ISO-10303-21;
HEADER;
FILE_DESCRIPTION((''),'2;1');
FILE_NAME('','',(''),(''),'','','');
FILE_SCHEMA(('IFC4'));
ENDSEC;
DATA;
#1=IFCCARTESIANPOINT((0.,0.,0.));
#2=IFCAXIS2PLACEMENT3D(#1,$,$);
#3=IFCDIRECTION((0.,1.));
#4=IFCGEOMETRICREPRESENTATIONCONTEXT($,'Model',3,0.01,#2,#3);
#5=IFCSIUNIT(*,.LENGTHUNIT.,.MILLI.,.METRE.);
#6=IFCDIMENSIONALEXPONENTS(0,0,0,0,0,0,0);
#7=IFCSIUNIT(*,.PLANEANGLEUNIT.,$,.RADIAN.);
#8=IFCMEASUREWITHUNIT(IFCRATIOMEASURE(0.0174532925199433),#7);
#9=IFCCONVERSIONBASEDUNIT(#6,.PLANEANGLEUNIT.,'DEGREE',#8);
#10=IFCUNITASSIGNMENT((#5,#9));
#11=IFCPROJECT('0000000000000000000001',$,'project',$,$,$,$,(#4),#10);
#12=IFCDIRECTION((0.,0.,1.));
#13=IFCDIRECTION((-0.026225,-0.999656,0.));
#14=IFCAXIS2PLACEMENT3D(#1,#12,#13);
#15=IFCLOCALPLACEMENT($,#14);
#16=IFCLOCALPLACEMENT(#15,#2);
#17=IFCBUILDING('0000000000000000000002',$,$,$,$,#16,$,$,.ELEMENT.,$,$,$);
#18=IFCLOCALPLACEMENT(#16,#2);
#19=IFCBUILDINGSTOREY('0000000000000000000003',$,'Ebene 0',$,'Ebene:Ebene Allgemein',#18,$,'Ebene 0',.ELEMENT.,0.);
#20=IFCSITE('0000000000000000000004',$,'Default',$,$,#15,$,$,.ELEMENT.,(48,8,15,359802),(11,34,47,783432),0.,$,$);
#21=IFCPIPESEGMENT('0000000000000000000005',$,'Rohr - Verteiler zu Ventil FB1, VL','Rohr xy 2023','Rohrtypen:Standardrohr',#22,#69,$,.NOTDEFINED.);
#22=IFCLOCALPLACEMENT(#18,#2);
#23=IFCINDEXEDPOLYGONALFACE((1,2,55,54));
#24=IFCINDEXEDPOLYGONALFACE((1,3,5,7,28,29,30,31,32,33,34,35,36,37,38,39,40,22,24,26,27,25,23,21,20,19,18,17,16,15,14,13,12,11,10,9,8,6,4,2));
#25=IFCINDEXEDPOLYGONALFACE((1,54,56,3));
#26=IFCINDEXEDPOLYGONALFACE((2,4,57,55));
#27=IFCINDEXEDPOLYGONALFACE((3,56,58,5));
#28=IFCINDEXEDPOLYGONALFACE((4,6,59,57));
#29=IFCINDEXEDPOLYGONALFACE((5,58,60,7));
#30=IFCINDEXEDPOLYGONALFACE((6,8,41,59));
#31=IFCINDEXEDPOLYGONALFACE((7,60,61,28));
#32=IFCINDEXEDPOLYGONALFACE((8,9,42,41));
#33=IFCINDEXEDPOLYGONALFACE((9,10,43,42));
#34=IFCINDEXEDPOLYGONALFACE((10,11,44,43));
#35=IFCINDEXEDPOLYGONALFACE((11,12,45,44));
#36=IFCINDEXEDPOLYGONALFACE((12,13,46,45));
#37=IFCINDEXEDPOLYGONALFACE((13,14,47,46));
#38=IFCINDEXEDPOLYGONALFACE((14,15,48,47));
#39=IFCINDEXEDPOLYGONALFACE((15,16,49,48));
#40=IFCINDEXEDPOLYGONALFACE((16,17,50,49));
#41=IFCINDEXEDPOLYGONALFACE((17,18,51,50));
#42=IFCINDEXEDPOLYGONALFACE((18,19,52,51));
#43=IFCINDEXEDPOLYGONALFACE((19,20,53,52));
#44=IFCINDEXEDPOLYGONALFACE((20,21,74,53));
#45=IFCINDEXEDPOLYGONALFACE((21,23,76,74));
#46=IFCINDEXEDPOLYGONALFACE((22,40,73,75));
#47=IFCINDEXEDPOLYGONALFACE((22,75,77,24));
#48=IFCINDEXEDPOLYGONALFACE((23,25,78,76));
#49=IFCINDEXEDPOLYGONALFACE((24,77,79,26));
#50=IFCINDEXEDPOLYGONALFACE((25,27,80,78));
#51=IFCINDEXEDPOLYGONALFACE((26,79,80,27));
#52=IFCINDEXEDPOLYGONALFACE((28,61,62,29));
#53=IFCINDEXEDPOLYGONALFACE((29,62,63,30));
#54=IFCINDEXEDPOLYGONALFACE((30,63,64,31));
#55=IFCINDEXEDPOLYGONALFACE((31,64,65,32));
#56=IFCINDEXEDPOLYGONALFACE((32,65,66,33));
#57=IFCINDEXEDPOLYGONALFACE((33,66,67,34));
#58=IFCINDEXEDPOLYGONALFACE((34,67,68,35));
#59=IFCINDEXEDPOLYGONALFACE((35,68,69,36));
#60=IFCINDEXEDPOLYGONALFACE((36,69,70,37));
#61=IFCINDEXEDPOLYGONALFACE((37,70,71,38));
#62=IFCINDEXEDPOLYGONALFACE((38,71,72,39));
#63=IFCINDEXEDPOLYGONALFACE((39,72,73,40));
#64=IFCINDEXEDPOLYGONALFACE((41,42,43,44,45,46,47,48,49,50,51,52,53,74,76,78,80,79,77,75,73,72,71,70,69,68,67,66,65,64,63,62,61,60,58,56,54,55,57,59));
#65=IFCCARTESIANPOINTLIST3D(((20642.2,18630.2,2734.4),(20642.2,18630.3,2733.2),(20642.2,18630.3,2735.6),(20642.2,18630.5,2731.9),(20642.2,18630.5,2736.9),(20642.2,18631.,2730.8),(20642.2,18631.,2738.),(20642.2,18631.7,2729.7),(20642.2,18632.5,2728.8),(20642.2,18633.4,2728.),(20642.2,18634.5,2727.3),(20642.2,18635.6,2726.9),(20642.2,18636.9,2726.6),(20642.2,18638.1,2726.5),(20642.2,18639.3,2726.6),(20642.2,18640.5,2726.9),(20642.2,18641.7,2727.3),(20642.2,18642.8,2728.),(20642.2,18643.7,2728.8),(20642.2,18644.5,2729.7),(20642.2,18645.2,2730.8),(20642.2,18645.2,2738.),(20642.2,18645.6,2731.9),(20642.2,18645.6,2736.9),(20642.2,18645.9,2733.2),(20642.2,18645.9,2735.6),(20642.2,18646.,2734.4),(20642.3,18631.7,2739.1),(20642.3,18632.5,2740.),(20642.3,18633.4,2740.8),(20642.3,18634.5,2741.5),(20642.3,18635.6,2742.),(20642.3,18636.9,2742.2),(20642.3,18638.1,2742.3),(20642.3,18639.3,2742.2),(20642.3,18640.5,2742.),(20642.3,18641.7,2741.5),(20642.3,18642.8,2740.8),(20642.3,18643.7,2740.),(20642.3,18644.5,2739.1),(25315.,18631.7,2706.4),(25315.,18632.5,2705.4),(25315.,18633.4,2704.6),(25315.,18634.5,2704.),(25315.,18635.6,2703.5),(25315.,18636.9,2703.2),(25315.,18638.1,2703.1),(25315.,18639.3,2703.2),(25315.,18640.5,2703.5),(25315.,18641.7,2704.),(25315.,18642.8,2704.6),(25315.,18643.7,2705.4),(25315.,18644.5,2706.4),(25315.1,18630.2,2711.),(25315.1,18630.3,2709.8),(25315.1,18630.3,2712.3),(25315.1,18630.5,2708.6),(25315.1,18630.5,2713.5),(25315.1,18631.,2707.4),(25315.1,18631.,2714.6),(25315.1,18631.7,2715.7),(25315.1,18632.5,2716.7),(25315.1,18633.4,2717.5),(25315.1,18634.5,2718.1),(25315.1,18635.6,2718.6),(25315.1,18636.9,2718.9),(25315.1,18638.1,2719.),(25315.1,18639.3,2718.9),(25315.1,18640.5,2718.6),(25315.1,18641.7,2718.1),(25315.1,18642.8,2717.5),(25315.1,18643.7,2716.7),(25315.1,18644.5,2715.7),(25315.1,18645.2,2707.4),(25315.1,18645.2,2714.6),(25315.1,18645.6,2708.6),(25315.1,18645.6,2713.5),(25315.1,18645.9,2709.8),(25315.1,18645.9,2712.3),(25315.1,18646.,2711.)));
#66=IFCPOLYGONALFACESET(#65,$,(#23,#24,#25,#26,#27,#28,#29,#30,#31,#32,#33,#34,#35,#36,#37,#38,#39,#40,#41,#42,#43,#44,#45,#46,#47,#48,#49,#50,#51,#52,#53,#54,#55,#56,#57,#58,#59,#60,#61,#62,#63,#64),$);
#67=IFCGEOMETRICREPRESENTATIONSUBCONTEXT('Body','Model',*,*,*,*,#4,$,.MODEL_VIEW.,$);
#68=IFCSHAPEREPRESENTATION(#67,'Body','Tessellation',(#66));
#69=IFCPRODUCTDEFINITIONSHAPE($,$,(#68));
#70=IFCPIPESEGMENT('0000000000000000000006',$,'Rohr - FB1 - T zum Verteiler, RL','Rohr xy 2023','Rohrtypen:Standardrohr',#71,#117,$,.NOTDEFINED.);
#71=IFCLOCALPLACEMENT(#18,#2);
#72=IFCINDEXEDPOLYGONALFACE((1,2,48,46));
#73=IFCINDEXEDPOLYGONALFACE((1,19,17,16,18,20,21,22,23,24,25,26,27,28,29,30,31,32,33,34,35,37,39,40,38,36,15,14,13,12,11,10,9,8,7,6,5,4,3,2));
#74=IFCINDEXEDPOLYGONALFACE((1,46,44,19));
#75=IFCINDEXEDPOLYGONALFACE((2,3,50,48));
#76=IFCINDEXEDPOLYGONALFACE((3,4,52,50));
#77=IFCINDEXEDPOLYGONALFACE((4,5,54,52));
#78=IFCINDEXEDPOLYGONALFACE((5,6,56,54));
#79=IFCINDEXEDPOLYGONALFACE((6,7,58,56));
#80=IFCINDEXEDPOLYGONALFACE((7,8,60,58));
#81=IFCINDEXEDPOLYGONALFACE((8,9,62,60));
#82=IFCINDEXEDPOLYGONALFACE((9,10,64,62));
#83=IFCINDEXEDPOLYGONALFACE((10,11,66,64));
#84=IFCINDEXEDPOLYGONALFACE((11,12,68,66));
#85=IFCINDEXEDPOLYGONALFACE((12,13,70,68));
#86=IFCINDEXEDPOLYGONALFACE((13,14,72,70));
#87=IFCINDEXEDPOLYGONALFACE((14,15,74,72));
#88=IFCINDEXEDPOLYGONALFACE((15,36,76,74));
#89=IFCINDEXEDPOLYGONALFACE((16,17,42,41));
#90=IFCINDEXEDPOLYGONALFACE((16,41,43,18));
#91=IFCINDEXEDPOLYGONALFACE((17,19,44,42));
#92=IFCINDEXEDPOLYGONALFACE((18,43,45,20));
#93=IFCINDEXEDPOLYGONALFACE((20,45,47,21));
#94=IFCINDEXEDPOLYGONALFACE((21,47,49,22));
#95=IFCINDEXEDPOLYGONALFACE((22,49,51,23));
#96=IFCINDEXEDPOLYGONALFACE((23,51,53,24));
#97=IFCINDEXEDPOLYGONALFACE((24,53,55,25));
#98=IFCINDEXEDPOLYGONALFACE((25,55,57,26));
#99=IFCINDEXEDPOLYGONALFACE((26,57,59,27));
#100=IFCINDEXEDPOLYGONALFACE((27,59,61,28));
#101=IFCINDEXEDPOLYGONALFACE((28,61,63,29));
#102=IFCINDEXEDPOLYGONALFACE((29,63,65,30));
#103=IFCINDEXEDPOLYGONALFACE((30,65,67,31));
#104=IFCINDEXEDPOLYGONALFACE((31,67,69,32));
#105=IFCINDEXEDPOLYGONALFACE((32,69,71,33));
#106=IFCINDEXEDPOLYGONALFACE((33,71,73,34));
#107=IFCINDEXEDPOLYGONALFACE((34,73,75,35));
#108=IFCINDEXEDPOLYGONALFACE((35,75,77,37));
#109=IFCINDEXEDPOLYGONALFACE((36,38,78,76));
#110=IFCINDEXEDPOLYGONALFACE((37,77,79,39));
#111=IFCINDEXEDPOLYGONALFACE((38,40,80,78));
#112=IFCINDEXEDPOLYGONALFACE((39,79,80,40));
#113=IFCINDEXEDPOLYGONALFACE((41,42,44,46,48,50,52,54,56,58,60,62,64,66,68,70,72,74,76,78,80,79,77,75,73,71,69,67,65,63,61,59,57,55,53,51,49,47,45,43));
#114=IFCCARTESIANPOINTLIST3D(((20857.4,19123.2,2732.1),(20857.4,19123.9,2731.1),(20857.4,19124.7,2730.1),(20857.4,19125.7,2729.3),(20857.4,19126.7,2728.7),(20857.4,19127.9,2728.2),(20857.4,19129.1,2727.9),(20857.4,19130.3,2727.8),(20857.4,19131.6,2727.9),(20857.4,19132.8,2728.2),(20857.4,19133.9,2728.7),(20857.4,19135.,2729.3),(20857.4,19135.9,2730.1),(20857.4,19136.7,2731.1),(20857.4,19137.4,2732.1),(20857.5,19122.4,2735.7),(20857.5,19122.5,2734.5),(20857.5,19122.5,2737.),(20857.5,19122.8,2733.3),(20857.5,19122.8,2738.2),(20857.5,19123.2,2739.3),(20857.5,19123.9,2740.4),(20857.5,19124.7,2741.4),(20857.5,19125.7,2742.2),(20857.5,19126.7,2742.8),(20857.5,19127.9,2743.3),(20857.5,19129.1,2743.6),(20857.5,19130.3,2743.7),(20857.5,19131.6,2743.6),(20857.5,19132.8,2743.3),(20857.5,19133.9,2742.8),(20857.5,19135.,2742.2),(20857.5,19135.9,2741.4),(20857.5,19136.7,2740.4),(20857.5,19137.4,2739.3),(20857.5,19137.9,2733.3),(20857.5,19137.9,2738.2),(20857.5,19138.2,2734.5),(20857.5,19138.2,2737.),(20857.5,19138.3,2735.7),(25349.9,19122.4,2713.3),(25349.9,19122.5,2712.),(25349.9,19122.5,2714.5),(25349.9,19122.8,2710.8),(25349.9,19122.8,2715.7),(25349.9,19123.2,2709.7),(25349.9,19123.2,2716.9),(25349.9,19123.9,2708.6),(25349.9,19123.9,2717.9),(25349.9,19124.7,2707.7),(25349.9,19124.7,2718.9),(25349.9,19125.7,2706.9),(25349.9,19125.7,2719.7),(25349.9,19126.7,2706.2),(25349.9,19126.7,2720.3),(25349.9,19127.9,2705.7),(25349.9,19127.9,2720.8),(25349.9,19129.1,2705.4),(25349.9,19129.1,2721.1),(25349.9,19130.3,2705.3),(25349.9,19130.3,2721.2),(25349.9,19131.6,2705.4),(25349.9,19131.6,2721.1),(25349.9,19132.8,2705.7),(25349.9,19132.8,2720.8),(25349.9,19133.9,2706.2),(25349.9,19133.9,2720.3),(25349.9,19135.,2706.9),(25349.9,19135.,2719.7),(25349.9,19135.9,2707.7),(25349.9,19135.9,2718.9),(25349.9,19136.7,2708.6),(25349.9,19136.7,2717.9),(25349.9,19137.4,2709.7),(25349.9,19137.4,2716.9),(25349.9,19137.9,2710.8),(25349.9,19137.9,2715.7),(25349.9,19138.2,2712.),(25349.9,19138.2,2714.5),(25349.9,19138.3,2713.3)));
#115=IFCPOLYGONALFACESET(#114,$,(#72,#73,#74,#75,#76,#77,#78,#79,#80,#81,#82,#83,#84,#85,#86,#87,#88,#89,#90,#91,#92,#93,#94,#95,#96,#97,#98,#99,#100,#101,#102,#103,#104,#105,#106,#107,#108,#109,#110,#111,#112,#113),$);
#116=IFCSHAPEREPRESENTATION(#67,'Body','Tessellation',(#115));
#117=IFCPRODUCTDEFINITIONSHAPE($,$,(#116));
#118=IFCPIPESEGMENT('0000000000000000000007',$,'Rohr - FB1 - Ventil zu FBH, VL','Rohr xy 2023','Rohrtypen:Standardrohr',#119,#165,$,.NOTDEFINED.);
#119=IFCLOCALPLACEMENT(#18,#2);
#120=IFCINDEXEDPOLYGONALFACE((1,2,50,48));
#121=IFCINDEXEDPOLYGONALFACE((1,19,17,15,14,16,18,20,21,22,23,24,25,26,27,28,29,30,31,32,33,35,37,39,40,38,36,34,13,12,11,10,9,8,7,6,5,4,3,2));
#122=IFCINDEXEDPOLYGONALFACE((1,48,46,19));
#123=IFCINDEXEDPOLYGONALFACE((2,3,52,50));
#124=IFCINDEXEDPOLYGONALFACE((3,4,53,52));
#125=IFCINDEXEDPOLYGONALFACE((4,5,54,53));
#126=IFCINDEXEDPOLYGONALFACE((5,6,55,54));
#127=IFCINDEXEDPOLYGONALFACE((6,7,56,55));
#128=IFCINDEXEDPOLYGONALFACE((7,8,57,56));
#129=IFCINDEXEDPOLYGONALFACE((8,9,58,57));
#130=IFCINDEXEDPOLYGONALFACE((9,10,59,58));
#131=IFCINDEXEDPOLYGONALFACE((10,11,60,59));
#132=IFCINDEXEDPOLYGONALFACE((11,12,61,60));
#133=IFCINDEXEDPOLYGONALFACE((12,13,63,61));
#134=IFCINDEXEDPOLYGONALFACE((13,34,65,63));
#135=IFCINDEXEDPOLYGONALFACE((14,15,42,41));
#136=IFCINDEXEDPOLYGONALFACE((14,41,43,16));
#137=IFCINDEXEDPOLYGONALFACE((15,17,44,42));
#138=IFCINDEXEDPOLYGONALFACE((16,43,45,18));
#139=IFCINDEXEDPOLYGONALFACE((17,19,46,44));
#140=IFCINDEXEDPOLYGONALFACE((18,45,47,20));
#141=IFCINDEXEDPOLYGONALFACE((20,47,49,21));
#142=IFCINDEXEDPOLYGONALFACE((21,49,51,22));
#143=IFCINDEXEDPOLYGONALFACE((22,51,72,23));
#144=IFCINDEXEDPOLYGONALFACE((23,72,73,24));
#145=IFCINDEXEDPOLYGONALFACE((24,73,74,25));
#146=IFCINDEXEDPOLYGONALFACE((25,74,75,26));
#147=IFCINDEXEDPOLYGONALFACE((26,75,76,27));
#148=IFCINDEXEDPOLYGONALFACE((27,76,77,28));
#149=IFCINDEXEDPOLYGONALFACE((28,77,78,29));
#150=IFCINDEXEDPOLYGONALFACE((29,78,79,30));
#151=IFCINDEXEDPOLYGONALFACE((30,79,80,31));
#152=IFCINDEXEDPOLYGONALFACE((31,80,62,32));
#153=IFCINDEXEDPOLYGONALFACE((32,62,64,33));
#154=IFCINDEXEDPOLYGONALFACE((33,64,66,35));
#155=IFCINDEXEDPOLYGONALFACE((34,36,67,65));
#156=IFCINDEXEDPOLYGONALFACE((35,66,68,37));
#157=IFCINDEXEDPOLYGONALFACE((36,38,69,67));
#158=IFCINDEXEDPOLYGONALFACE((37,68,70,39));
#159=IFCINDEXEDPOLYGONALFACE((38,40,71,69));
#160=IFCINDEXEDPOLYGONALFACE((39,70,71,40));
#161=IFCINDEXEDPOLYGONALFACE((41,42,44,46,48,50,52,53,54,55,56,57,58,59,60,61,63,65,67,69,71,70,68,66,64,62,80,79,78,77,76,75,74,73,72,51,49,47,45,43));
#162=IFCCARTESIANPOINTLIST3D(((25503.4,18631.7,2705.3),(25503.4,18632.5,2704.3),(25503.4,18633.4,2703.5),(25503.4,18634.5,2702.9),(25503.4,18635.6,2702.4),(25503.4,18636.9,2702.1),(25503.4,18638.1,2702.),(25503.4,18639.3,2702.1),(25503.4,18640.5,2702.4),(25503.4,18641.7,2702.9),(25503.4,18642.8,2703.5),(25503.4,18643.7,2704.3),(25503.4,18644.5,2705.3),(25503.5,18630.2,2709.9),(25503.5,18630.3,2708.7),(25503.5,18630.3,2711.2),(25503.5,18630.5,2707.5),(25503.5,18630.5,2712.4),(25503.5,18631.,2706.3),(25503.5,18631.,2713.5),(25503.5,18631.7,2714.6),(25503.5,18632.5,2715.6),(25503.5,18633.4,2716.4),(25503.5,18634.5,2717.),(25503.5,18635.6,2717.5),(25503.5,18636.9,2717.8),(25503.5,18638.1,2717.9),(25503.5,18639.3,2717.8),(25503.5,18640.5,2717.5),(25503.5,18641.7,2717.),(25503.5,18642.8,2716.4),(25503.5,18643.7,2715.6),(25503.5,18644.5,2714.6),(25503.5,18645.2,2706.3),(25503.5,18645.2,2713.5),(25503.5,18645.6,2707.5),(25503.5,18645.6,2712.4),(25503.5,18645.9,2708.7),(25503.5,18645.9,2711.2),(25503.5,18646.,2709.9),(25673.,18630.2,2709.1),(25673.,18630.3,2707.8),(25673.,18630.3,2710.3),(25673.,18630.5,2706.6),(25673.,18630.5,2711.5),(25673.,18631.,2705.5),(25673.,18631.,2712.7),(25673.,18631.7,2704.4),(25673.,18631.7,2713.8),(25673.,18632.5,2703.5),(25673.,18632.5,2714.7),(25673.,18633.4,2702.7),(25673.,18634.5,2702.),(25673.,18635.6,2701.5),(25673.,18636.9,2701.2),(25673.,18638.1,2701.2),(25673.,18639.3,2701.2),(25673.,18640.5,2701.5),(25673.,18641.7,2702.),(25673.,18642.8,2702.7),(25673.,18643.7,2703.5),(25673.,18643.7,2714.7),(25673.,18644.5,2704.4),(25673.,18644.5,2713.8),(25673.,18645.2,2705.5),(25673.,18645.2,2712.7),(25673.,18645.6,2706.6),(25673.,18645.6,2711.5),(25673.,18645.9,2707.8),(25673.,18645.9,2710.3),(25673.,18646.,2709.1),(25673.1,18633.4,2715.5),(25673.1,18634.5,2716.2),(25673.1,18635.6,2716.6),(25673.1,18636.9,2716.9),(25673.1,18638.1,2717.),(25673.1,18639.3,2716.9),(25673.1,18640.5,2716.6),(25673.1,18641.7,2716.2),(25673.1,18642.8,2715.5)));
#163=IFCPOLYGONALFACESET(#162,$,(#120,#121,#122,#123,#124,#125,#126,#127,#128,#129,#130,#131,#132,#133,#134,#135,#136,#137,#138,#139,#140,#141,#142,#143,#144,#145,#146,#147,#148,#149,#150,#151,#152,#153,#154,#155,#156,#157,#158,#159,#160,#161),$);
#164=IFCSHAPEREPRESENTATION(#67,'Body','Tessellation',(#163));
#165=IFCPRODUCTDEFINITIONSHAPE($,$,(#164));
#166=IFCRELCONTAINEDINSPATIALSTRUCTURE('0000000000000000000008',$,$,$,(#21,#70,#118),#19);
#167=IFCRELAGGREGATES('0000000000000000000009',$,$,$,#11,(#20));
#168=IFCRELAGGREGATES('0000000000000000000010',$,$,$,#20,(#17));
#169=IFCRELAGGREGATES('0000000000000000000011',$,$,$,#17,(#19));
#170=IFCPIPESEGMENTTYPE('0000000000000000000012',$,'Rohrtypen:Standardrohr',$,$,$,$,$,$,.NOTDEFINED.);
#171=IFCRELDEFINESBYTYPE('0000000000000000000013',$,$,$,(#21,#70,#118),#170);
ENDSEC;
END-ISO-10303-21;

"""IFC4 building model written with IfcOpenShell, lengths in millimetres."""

from ifc_helpers import new_model, entity, si_unit, converted_unit, direction, frame, origin, place, context, subcontext, project, spatial, indexed_curve, outline, extrude, type_object, element, save


model = new_model("IFC4")

# Units and contexts
model_context = context("Model", 3, precision=0.01, world=origin(), true_north=direction((0.0, 1.0)))
body_context = subcontext(model_context, "Body", "Model", "MODEL_VIEW")
ifc_project = project(units=[si_unit("LENGTHUNIT", "METRE", prefix="MILLI"), converted_unit("PLANEANGLEUNIT", "DEGREE", entity("IfcRatioMeasure", 0.0174532925199433), si_unit("PLANEANGLEUNIT", "RADIAN"), dimensions=[0, 0, 0, 0, 0, 0, 0])], contexts=[model_context])

# Site, building, storey
site_placement = place(None, frame((0.0, 0.0, 0.0), z_axis=(0.0, 0.0, 1.0), x_axis=(-0.026225, -0.999656, 0.0)))
site = spatial("IfcSite", under=ifc_project, at=site_placement, Name="Default", CompositionType="ELEMENT", RefLatitude=(48, 8, 15, 359802), RefLongitude=(11, 34, 47, 783432), RefElevation=0.0)
building_placement = place(site_placement, origin())
building = spatial("IfcBuilding", under=site, at=building_placement, CompositionType="ELEMENT")
storey_placement = place(building_placement, origin())
storey = spatial("IfcBuildingStorey", under=building, at=storey_placement, Name="Ebene 0", ObjectType="Ebene:Ebene Allgemein", LongName="Ebene 0", CompositionType="ELEMENT", Elevation=0.0)

# Pipe segments
pipe_segment_type = type_object("IfcPipeSegmentType", Name="Rohrtypen:Standardrohr", PredefinedType="NOTDEFINED")
pipe_segment_1_placement = place(storey_placement, origin())
element("IfcPipeSegment", 1, at=pipe_segment_1_placement, inside=storey, type_object=pipe_segment_type, Name="Rohr - Verteiler zu Ventil FB1, VL", Description="Rohr xy 2023", ObjectType="Rohrtypen:Standardrohr", PredefinedType="NOTDEFINED", context=body_context, shape_type="SweptSolid", body=[
    extrude(outline(indexed_curve([(7.9, 0.0), (7.8, 1.2), (7.6, 2.5), (7.1, 3.6), (6.4, 4.7), (5.6, 5.6), (4.7, 6.4), (3.6, 7.1), (2.5, 7.6), (1.2, 7.8), (0.0, 7.9), (-1.2, 7.8), (-2.5, 7.6), (-3.6, 7.1), (-4.7, 6.4), (-5.6, 5.6), (-6.4, 4.7), (-7.1, 3.6), (-7.6, 2.5), (-7.8, 1.2), (-7.9, 0.0), (-7.8, -1.2), (-7.6, -2.5), (-7.1, -3.6), (-6.4, -4.7), (-5.6, -5.6), (-4.7, -6.4), (-3.6, -7.1), (-2.5, -7.6), (-1.2, -7.8), (0.0, -7.9), (1.2, -7.8), (2.5, -7.6), (3.6, -7.1), (4.7, -6.4), (5.6, -5.6), (6.4, -4.7), (7.1, -3.6), (7.6, -2.5), (7.8, -1.2), (7.9, 0.0)], self_intersect=False)), frame((25315.1, 18638.1, 2711.0), z_axis=(-0.999988, 0.0, 0.005), x_axis=(0.0, 1.0, 0.0)), (0.0, 0.0, 1.0), 4672.9),
])
pipe_segment_2_placement = place(storey_placement, origin())
element("IfcPipeSegment", 2, at=pipe_segment_2_placement, inside=storey, type_object=pipe_segment_type, Name="Rohr - FB1 - T zum Verteiler, RL", Description="Rohr xy 2023", ObjectType="Rohrtypen:Standardrohr", PredefinedType="NOTDEFINED", context=body_context, shape_type="SweptSolid", body=[
    extrude(outline(indexed_curve([(7.9, 0.0), (7.8, 1.2), (7.6, 2.5), (7.1, 3.6), (6.4, 4.7), (5.6, 5.6), (4.7, 6.4), (3.6, 7.1), (2.5, 7.6), (1.2, 7.8), (0.0, 7.9), (-1.2, 7.8), (-2.5, 7.6), (-3.6, 7.1), (-4.7, 6.4), (-5.6, 5.6), (-6.4, 4.7), (-7.1, 3.6), (-7.6, 2.5), (-7.8, 1.2), (-7.9, 0.0), (-7.8, -1.2), (-7.6, -2.5), (-7.1, -3.6), (-6.4, -4.7), (-5.6, -5.6), (-4.7, -6.4), (-3.6, -7.1), (-2.5, -7.6), (-1.2, -7.8), (0.0, -7.9), (1.2, -7.8), (2.5, -7.6), (3.6, -7.1), (4.7, -6.4), (5.6, -5.6), (6.4, -4.7), (7.1, -3.6), (7.6, -2.5), (7.8, -1.2), (7.9, 0.0)], self_intersect=False)), frame((25349.9, 19130.3, 2713.3), z_axis=(-0.999988, 0.0, 0.005), x_axis=(0.0, 1.0, 0.0)), (0.0, 0.0, 1.0), 4492.5),
])
pipe_segment_3_placement = place(storey_placement, origin())
element("IfcPipeSegment", 3, at=pipe_segment_3_placement, inside=storey, type_object=pipe_segment_type, Name="Rohr - FB1 - Ventil zu FBH, VL", Description="Rohr xy 2023", ObjectType="Rohrtypen:Standardrohr", PredefinedType="NOTDEFINED", context=body_context, shape_type="SweptSolid", body=[
    extrude(outline(indexed_curve([(7.9, 0.0), (7.8, 1.2), (7.6, 2.5), (7.1, 3.6), (6.4, 4.7), (5.6, 5.6), (4.7, 6.4), (3.6, 7.1), (2.5, 7.6), (1.2, 7.8), (0.0, 7.9), (-1.2, 7.8), (-2.5, 7.6), (-3.6, 7.1), (-4.7, 6.4), (-5.6, 5.6), (-6.4, 4.7), (-7.1, 3.6), (-7.6, 2.5), (-7.8, 1.2), (-7.9, 0.0), (-7.8, -1.2), (-7.6, -2.5), (-7.1, -3.6), (-6.4, -4.7), (-5.6, -5.6), (-4.7, -6.4), (-3.6, -7.1), (-2.5, -7.6), (-1.2, -7.8), (0.0, -7.9), (1.2, -7.8), (2.5, -7.6), (3.6, -7.1), (4.7, -6.4), (5.6, -5.6), (6.4, -4.7), (7.1, -3.6), (7.6, -2.5), (7.8, -1.2), (7.9, 0.0)], self_intersect=False)), frame((25503.5, 18638.1, 2709.9), z_axis=(0.999988, 0.0, -0.005), x_axis=(0.0, 1.0, 0.0)), (0.0, 0.0, 1.0), 169.5),
])

save(model, "model.ifc")
